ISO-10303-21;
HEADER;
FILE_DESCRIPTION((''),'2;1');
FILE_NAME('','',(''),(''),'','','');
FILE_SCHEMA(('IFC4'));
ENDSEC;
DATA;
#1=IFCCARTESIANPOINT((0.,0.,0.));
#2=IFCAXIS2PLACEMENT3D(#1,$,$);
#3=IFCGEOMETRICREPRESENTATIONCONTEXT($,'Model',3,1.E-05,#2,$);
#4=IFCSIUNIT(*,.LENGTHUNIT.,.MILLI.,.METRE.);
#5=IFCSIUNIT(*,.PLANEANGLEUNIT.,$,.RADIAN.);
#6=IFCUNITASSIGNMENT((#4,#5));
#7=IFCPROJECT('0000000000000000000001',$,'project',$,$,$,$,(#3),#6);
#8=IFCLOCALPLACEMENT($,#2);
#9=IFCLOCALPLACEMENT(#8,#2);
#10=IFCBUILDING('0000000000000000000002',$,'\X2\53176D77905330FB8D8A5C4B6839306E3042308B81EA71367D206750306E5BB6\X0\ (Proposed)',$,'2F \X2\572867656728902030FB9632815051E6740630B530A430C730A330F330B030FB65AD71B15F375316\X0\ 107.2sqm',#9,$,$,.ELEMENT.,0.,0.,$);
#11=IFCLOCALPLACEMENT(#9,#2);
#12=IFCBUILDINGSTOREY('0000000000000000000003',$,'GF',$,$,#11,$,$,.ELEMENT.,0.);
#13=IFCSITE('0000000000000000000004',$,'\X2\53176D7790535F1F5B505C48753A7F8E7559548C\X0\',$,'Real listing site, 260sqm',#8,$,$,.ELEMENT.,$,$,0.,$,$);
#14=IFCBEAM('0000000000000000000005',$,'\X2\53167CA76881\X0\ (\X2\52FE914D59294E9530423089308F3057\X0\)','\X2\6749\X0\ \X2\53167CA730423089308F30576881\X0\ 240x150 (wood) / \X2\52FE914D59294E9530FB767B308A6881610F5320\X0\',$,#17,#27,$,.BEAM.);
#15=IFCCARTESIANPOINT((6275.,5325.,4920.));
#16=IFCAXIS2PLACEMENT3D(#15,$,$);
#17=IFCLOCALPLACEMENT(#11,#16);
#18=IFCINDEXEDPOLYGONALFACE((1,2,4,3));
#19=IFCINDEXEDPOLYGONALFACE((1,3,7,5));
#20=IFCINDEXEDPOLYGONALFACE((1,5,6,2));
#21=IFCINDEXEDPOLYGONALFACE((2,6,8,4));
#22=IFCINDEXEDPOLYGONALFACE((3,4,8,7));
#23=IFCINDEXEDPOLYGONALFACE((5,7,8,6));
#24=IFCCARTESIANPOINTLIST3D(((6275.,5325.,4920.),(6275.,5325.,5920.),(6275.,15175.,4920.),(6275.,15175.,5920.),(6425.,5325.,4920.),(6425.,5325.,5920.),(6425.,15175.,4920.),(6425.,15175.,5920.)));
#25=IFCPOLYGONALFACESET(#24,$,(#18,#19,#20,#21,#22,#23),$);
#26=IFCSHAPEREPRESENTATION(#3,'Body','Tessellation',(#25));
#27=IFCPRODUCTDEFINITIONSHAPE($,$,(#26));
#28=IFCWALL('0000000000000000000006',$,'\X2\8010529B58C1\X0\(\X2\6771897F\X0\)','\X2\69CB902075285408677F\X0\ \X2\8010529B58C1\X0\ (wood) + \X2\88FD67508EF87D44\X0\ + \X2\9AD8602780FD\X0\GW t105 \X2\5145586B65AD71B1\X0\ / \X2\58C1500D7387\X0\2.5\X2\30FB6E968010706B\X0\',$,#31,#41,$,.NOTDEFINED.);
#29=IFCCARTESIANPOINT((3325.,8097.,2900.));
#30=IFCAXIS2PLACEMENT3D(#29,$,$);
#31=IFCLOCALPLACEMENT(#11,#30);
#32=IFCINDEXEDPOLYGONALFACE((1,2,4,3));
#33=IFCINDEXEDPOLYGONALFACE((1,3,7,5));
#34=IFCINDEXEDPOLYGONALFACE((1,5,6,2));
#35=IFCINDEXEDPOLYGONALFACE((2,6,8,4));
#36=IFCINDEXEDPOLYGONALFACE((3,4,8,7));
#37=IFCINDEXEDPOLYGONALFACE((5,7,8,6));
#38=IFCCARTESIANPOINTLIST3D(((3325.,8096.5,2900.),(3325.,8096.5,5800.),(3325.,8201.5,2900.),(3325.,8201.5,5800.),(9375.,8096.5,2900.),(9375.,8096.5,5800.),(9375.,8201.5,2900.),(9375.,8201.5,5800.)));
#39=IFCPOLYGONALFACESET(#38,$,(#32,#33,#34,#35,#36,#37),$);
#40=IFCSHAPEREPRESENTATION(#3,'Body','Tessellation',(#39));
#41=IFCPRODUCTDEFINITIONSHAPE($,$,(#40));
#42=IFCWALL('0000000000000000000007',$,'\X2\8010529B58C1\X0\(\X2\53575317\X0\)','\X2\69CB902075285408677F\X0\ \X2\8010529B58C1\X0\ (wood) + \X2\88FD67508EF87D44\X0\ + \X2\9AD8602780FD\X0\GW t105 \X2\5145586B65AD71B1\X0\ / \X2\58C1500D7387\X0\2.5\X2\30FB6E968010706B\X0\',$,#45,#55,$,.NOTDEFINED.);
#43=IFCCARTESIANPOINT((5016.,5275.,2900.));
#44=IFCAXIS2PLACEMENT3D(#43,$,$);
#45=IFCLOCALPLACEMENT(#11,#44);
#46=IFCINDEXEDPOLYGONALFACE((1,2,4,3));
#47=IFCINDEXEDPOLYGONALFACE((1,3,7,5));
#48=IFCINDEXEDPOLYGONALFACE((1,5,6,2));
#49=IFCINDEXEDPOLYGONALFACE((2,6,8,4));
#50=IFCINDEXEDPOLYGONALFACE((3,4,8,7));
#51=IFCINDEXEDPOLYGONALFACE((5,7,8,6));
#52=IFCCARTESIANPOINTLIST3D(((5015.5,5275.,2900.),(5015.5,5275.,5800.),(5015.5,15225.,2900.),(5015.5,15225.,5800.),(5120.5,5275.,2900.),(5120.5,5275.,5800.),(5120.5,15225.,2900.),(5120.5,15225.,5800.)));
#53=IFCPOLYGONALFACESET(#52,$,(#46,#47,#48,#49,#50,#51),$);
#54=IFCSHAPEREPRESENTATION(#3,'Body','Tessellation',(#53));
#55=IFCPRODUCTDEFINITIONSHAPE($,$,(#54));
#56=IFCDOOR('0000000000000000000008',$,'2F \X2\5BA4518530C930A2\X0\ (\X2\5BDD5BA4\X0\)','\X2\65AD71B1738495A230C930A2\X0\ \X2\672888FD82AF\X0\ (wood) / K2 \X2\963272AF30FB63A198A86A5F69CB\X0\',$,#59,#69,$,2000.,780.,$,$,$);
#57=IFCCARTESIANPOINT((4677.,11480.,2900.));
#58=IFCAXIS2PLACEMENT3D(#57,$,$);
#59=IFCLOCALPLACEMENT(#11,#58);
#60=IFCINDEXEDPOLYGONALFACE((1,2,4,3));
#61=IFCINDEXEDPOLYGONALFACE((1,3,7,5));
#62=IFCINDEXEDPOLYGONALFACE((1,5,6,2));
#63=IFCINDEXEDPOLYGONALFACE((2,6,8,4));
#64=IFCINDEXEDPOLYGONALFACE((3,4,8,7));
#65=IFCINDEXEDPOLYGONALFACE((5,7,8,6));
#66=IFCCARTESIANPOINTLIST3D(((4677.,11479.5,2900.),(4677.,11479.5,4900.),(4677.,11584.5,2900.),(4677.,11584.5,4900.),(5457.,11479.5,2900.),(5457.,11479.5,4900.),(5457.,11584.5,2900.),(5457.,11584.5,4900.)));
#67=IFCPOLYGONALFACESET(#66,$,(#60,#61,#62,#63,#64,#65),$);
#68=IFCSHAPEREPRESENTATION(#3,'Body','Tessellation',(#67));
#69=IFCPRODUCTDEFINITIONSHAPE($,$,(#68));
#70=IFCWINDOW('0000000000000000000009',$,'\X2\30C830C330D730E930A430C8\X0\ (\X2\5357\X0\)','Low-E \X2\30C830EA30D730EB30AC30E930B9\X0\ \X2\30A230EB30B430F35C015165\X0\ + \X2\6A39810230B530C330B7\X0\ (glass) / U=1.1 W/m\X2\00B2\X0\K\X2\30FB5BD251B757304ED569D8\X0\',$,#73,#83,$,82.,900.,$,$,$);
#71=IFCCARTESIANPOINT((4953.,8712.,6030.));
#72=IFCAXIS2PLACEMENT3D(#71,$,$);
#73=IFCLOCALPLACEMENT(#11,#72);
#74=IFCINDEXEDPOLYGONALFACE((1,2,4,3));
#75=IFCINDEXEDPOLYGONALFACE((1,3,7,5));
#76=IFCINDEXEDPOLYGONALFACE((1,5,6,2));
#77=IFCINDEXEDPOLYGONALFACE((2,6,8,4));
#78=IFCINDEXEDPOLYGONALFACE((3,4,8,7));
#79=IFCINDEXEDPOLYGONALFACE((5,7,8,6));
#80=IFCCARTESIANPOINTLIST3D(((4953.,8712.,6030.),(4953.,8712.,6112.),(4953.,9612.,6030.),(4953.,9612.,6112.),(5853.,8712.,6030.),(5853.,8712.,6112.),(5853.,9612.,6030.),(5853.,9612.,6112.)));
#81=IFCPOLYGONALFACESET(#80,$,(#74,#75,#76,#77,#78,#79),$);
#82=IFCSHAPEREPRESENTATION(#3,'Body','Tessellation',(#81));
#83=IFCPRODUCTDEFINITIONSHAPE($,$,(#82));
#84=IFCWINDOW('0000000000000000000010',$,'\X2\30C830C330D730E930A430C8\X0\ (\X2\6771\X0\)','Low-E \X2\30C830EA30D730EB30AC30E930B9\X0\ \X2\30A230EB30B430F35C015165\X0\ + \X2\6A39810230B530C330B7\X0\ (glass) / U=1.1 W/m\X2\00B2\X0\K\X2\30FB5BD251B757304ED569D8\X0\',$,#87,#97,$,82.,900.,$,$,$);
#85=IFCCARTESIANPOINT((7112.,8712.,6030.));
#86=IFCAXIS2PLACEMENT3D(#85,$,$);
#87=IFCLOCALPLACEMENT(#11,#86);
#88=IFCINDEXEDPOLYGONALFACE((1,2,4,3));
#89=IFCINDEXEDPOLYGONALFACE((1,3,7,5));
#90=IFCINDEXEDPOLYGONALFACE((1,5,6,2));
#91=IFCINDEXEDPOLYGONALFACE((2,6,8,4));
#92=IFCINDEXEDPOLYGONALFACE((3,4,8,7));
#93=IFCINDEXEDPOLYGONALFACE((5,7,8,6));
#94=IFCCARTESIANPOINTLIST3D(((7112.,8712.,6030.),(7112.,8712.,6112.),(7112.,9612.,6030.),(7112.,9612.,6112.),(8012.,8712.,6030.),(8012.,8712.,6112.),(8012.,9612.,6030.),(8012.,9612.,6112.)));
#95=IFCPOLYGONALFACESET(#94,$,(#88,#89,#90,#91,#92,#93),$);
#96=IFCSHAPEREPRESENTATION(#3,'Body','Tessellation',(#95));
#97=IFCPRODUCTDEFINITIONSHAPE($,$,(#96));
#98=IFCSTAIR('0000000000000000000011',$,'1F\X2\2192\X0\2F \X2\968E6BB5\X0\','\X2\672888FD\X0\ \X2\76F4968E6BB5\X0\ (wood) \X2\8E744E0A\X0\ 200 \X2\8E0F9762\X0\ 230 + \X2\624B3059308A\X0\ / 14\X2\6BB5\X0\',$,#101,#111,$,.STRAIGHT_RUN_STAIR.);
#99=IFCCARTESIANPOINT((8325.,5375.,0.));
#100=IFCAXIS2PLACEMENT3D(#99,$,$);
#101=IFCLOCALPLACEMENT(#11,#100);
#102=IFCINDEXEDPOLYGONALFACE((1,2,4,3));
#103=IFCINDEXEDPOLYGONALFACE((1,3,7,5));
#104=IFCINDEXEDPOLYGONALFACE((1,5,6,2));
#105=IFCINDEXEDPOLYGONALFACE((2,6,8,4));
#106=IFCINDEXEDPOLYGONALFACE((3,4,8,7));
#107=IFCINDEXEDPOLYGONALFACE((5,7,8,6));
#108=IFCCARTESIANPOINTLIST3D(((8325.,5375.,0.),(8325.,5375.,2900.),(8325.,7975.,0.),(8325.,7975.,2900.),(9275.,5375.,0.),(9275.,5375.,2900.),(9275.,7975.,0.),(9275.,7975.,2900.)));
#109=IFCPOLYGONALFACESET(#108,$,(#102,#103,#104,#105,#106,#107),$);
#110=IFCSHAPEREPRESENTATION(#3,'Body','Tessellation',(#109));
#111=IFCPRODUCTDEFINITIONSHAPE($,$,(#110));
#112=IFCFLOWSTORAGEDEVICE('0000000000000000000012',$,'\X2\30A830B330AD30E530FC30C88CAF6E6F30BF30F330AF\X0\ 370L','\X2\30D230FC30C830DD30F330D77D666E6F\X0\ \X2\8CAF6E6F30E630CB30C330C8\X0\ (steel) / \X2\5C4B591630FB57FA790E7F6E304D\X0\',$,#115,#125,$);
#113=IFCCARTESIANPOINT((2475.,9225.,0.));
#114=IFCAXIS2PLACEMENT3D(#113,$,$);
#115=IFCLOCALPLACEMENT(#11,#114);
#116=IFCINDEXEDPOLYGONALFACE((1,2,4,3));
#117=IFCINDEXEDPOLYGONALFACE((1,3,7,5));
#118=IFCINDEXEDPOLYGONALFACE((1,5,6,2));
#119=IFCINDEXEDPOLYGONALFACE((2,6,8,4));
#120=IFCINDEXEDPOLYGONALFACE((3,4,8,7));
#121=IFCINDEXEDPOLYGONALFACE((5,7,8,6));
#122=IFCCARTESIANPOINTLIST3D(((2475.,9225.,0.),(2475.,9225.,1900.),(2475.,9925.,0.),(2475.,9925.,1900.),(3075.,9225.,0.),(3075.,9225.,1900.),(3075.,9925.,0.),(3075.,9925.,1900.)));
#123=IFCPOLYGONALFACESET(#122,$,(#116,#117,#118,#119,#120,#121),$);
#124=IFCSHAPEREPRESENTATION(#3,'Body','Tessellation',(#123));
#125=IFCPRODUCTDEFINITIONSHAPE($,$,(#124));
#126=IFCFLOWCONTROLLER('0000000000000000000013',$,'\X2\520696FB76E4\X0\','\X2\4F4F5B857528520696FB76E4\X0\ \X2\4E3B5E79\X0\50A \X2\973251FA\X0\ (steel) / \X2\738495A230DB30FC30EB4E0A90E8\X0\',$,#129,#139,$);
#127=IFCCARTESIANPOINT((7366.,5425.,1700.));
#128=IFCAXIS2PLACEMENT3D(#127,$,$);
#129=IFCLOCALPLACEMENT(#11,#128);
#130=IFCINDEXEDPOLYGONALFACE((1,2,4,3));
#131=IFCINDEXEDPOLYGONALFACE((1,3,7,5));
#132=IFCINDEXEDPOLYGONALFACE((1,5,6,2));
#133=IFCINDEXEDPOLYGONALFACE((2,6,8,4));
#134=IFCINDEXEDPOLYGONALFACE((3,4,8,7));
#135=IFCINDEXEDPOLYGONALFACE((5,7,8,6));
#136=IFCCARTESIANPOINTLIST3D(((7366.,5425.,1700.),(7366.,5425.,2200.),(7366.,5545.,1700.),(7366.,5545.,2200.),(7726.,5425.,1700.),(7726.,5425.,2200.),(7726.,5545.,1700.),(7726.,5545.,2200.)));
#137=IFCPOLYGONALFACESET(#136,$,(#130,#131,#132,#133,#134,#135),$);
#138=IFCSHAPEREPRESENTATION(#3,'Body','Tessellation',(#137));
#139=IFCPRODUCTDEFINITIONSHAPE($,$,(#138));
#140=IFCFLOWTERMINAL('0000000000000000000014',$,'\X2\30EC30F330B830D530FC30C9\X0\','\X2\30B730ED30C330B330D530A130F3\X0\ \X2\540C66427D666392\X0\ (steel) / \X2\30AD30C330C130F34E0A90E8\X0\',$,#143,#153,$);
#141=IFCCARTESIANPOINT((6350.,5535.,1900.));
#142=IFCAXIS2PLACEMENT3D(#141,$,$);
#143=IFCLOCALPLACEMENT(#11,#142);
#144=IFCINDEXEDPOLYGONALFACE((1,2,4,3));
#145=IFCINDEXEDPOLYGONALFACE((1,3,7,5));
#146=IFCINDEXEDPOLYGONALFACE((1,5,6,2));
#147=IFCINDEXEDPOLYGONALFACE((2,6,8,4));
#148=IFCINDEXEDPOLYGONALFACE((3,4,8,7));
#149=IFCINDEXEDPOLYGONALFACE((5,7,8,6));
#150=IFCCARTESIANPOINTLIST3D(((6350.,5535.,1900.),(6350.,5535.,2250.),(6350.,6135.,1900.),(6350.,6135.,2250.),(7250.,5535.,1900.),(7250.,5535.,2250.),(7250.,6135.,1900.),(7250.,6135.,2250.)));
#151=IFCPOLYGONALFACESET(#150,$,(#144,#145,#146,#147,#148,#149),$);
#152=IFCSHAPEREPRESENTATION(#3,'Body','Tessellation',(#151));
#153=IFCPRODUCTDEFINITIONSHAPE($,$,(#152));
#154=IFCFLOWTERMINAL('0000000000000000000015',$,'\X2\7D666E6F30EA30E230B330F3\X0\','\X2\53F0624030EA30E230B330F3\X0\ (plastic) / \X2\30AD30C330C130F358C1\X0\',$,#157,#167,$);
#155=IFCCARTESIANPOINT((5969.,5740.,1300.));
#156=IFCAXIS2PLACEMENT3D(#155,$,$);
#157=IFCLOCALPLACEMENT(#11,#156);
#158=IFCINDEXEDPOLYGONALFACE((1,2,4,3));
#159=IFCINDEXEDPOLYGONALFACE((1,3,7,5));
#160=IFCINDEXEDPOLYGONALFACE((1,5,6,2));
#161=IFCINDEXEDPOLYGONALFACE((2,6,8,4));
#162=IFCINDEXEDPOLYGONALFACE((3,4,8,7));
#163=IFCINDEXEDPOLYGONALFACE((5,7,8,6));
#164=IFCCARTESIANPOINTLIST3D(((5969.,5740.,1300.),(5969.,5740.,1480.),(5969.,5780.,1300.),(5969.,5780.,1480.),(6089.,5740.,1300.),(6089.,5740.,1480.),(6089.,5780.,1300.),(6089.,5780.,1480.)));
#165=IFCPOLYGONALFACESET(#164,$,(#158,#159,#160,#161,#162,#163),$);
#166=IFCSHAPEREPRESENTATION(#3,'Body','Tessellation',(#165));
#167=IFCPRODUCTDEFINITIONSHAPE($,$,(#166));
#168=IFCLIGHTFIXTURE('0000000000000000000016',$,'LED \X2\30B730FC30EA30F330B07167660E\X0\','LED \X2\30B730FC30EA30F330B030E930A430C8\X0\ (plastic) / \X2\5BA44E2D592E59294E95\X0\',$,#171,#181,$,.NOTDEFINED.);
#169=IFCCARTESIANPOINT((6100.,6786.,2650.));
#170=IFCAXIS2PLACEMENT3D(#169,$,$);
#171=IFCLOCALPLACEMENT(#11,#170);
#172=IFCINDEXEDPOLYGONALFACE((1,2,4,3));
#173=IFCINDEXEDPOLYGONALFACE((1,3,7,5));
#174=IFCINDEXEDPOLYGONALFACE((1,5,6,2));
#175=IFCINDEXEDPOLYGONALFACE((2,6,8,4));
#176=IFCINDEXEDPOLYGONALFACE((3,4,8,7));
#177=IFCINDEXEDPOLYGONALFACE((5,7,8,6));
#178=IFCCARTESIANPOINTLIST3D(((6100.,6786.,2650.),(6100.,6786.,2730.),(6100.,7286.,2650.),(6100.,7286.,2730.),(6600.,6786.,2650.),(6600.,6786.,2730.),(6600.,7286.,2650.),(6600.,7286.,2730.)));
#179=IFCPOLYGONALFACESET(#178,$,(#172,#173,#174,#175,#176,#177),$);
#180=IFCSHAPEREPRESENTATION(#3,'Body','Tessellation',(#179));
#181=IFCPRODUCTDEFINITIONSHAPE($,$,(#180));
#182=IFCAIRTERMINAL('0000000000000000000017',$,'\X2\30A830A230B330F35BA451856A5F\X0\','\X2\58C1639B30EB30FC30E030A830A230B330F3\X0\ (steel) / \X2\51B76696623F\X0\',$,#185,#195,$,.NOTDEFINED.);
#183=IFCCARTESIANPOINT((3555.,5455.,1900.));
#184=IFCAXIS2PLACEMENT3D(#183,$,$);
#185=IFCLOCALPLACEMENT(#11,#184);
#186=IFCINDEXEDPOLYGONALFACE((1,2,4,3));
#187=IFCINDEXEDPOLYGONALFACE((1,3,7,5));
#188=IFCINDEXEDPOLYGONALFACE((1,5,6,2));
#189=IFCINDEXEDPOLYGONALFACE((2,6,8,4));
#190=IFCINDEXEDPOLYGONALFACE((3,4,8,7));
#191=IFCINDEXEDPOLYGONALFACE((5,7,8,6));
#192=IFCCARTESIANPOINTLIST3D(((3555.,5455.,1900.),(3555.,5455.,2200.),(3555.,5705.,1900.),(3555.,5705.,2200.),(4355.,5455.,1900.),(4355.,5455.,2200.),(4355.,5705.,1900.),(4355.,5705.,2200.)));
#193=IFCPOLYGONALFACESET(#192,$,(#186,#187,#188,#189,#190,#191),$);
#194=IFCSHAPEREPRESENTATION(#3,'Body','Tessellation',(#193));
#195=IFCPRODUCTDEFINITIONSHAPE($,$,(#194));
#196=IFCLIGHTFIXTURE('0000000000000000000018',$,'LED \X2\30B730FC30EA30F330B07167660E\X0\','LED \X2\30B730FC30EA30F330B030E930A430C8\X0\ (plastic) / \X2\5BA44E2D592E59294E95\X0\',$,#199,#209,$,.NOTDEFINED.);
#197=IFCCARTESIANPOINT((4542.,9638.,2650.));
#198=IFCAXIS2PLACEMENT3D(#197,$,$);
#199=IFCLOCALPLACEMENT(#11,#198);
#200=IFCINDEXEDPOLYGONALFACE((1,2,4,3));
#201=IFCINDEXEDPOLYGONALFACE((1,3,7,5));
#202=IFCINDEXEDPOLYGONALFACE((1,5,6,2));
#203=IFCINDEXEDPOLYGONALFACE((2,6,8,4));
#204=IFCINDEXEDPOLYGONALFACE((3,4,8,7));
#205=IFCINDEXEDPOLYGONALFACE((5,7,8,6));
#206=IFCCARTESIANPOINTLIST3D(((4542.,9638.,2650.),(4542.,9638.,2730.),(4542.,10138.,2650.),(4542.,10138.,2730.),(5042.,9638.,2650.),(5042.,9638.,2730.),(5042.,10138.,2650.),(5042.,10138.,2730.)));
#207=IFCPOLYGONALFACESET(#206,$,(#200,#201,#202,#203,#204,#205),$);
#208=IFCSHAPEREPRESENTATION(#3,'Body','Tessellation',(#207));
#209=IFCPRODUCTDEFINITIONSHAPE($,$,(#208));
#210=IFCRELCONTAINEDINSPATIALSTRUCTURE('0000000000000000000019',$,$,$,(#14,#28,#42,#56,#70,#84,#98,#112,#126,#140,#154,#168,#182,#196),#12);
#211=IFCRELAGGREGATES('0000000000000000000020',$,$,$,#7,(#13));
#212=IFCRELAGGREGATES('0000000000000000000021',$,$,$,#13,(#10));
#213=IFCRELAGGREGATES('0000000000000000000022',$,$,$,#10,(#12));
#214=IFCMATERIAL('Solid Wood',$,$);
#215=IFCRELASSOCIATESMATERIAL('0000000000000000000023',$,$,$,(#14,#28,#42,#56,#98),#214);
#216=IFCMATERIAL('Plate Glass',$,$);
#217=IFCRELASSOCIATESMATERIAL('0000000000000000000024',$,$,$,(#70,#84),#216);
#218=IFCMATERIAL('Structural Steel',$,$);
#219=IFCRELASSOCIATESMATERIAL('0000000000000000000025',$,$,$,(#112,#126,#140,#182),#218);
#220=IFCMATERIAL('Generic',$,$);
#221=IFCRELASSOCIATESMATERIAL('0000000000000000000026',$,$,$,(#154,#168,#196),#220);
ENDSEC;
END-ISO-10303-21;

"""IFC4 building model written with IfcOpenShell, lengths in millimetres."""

from ifc_helpers import new_model, si_unit, frame, frame_2d, origin, place, context, project, spatial, rectangle, extrude, material, element, fill, save


model = new_model("IFC4")

# Units and contexts
model_context = context("Model", 3, precision=1e-05, world=origin())
ifc_project = project(units=[si_unit("LENGTHUNIT", "METRE", prefix="MILLI"), si_unit("PLANEANGLEUNIT", "RADIAN")], contexts=[model_context])

# Site, building, storey
site_placement = place(None, origin())
site = spatial("IfcSite", under=ifc_project, at=site_placement, Name="北海道弟子屈町美留和", ObjectType="Real listing site, 260sqm", CompositionType="ELEMENT", RefElevation=0.0)
building_placement = place(site_placement, origin())
building = spatial("IfcBuilding", under=site, at=building_placement, Name="北海道・越屋根のある自然素材の家 (Proposed)", ObjectType="2F 在来木造・防腐処理サイディング・断熱強化 107.2sqm", CompositionType="ELEMENT", ElevationOfRefHeight=0.0, ElevationOfTerrain=0.0)
storey_placement = place(building_placement, origin())
storey = spatial("IfcBuildingStorey", under=building, at=storey_placement, Name="GF", CompositionType="ELEMENT", Elevation=0.0)

# Shared definitions
ifc_material_1 = material(Name="Solid Wood")

# Beam
beam_placement = place(storey_placement, frame((6275.0, 5325.0, 4920.0)))
element("IfcBeam", 1, at=beam_placement, inside=storey, material=ifc_material_1, Name="化粧梁 (勾配天井あらわし)", Description="杉 化粧あらわし梁 240x150 (wood) / 勾配天井・登り梁意匠", PredefinedType="BEAM", context=model_context, shape_type="SweptSolid", body=[
    extrude(rectangle(XDim=150.0, YDim=9850.0, at=frame_2d((75.0, 4925.0))), frame((6275.0, 5325.0, 4920.0)), (0.0, 0.0, 1.0), 1000.0),
])

# Wall
wall_1_placement = place(storey_placement, frame((3325.0, 8097.0, 2900.0)))
element("IfcWall", 2, at=wall_1_placement, inside=storey, material=ifc_material_1, Name="耐力壁(東西)", Description="構造用合板 耐力壁 (wood) + 製材軸組 + 高性能GW t105 充填断熱 / 壁倍率2.5・準耐火", PredefinedType="NOTDEFINED", context=model_context, shape_type="SweptSolid", body=[
    extrude(rectangle(XDim=6050.0, YDim=105.0, at=frame_2d((3025.0, 52.0))), frame((3325.0, 8097.0, 2900.0)), (0.0, 0.0, 1.0), 2900.0),
])

# Wall, opening, door
wall_2_placement = place(storey_placement, frame((5016.0, 5275.0, 2900.0)))
wall_2 = element("IfcWall", 3, at=wall_2_placement, inside=storey, material=ifc_material_1, Name="耐力壁(南北)", Description="構造用合板 耐力壁 (wood) + 製材軸組 + 高性能GW t105 充填断熱 / 壁倍率2.5・準耐火", PredefinedType="NOTDEFINED", context=model_context, shape_type="SweptSolid", body=[
    extrude(rectangle(XDim=105.0, YDim=9950.0, at=frame_2d((52.0, 4975.0))), frame((5016.0, 5275.0, 2900.0)), (0.0, 0.0, 1.0), 2900.0),
])
opening_placement = place(storey_placement, frame((4677.0, 11480.0, 2900.0)))
opening = element("IfcOpeningElement", 4, at=opening_placement, cuts=wall_2, PredefinedType="NOTDEFINED", context=model_context, shape_type="SweptSolid", body=[
    extrude(rectangle(XDim=780.0, YDim=105.0, at=frame_2d((390.0, 52.0))), frame((4677.0, 11480.0, 2900.0)), (0.0, 0.0, 1.0), 2000.0),
])
door_placement = place(storey_placement, frame((4677.0, 11480.0, 2900.0)))
door = element("IfcDoor", 5, at=door_placement, inside=storey, material=ifc_material_1, Name="2F 室内ドア (寝室)", Description="断熱玄関ドア 木製芯 (wood) / K2 防犯・採風機構", OverallHeight=2000.0, OverallWidth=780.0, context=model_context, shape_type="SweptSolid", body=[
    extrude(rectangle(XDim=780.0, YDim=105.0, at=frame_2d((390.0, 52.0))), frame((4677.0, 11480.0, 2900.0)), (0.0, 0.0, 1.0), 2000.0),
])
fill(opening, door)

# Windows
ifc_material_2 = material(Name="Plate Glass")
window_1_placement = place(storey_placement, frame((4953.0, 8712.0, 6030.0)))
element("IfcWindow", 6, at=window_1_placement, inside=storey, material=ifc_material_2, Name="トップライト (南)", Description="Low-E トリプルガラス アルゴン封入 + 樹脂サッシ (glass) / U=1.1 W/m²K・寒冷地仕様", OverallHeight=82.0, OverallWidth=900.0, context=model_context, shape_type="SweptSolid", body=[
    extrude(rectangle(XDim=900.0, YDim=900.0, at=frame_2d((450.0, 450.0))), frame((4953.0, 8712.0, 6030.0)), (0.0, 0.0, 1.0), 82.0),
])
window_2_placement = place(storey_placement, frame((7112.0, 8712.0, 6030.0)))
element("IfcWindow", 7, at=window_2_placement, inside=storey, material=ifc_material_2, Name="トップライト (東)", Description="Low-E トリプルガラス アルゴン封入 + 樹脂サッシ (glass) / U=1.1 W/m²K・寒冷地仕様", OverallHeight=82.0, OverallWidth=900.0, context=model_context, shape_type="SweptSolid", body=[
    extrude(rectangle(XDim=900.0, YDim=900.0, at=frame_2d((450.0, 450.0))), frame((7112.0, 8712.0, 6030.0)), (0.0, 0.0, 1.0), 82.0),
])

# Stair
stair_placement = place(storey_placement, frame((8325.0, 5375.0, 0.0)))
element("IfcStair", 8, at=stair_placement, inside=storey, material=ifc_material_1, Name="1F→2F 階段", Description="木製 直階段 (wood) 蹴上 200 踏面 230 + 手すり / 14段", PredefinedType="STRAIGHT_RUN_STAIR", context=model_context, shape_type="SweptSolid", body=[
    extrude(rectangle(XDim=950.0, YDim=2600.0, at=frame_2d((475.0, 1300.0))), frame((8325.0, 5375.0, 0.0)), (0.0, 0.0, 1.0), 2900.0),
])

# Flow storage device
ifc_material_3 = material(Name="Structural Steel")
flow_storage_device_placement = place(storey_placement, frame((2475.0, 9225.0, 0.0)))
element("IfcFlowStorageDevice", 9, at=flow_storage_device_placement, inside=storey, material=ifc_material_3, Name="エコキュート貯湯タンク 370L", Description="ヒートポンプ給湯 貯湯ユニット (steel) / 屋外・基礎置き", context=model_context, shape_type="SweptSolid", body=[
    extrude(rectangle(XDim=600.0, YDim=700.0, at=frame_2d((300.0, 350.0))), frame((2475.0, 9225.0, 0.0)), (0.0, 0.0, 1.0), 1900.0),
])

# Flow controller
flow_controller_placement = place(storey_placement, frame((7366.0, 5425.0, 1700.0)))
element("IfcFlowController", 10, at=flow_controller_placement, inside=storey, material=ifc_material_3, Name="分電盤", Description="住宅用分電盤 主幹50A 露出 (steel) / 玄関ホール上部", context=model_context, shape_type="SweptSolid", body=[
    extrude(rectangle(XDim=360.0, YDim=120.0, at=frame_2d((180.0, 60.0))), frame((7366.0, 5425.0, 1700.0)), (0.0, 0.0, 1.0), 500.0),
])

# Flow terminals
flow_terminal_1_placement = place(storey_placement, frame((6350.0, 5535.0, 1900.0)))
element("IfcFlowTerminal", 11, at=flow_terminal_1_placement, inside=storey, material=ifc_material_3, Name="レンジフード", Description="シロッコファン 同時給排 (steel) / キッチン上部", context=model_context, shape_type="SweptSolid", body=[
    extrude(rectangle(XDim=900.0, YDim=600.0, at=frame_2d((450.0, 300.0))), frame((6350.0, 5535.0, 1900.0)), (0.0, 0.0, 1.0), 350.0),
])
ifc_material_4 = material(Name="Generic")
flow_terminal_2_placement = place(storey_placement, frame((5969.0, 5740.0, 1300.0)))
element("IfcFlowTerminal", 12, at=flow_terminal_2_placement, inside=storey, material=ifc_material_4, Name="給湯リモコン", Description="台所リモコン (plastic) / キッチン壁", context=model_context, shape_type="SweptSolid", body=[
    extrude(rectangle(XDim=120.0, YDim=40.0, at=frame_2d((60.0, 20.0))), frame((5969.0, 5740.0, 1300.0)), (0.0, 0.0, 1.0), 180.0),
])

# Light fixture
light_fixture_1_placement = place(storey_placement, frame((6100.0, 6786.0, 2650.0)))
element("IfcLightFixture", 13, at=light_fixture_1_placement, inside=storey, material=ifc_material_4, Name="LED シーリング照明", Description="LED シーリングライト (plastic) / 室中央天井", PredefinedType="NOTDEFINED", context=model_context, shape_type="SweptSolid", body=[
    extrude(rectangle(XDim=500.0, YDim=500.0, at=frame_2d((250.0, 250.0))), frame((6100.0, 6786.0, 2650.0)), (0.0, 0.0, 1.0), 80.0),
])

# Air terminal
air_terminal_1_placement = place(storey_placement, frame((3555.0, 5455.0, 1900.0)))
element("IfcAirTerminal", 14, at=air_terminal_1_placement, inside=storey, material=ifc_material_3, Name="エアコン室内機", Description="壁掛ルームエアコン (steel) / 冷暖房", PredefinedType="NOTDEFINED", context=model_context, shape_type="SweptSolid", body=[
    extrude(rectangle(XDim=800.0, YDim=250.0, at=frame_2d((400.0, 125.0))), frame((3555.0, 5455.0, 1900.0)), (0.0, 0.0, 1.0), 300.0),
])

# Light fixture
light_fixture_2_placement = place(storey_placement, frame((4542.0, 9638.0, 2650.0)))
element("IfcLightFixture", 15, at=light_fixture_2_placement, inside=storey, material=ifc_material_4, Name="LED シーリング照明", Description="LED シーリングライト (plastic) / 室中央天井", PredefinedType="NOTDEFINED", context=model_context, shape_type="SweptSolid", body=[
    extrude(rectangle(XDim=500.0, YDim=500.0, at=frame_2d((250.0, 250.0))), frame((4542.0, 9638.0, 2650.0)), (0.0, 0.0, 1.0), 80.0),
])

save(model, "model.ifc")
